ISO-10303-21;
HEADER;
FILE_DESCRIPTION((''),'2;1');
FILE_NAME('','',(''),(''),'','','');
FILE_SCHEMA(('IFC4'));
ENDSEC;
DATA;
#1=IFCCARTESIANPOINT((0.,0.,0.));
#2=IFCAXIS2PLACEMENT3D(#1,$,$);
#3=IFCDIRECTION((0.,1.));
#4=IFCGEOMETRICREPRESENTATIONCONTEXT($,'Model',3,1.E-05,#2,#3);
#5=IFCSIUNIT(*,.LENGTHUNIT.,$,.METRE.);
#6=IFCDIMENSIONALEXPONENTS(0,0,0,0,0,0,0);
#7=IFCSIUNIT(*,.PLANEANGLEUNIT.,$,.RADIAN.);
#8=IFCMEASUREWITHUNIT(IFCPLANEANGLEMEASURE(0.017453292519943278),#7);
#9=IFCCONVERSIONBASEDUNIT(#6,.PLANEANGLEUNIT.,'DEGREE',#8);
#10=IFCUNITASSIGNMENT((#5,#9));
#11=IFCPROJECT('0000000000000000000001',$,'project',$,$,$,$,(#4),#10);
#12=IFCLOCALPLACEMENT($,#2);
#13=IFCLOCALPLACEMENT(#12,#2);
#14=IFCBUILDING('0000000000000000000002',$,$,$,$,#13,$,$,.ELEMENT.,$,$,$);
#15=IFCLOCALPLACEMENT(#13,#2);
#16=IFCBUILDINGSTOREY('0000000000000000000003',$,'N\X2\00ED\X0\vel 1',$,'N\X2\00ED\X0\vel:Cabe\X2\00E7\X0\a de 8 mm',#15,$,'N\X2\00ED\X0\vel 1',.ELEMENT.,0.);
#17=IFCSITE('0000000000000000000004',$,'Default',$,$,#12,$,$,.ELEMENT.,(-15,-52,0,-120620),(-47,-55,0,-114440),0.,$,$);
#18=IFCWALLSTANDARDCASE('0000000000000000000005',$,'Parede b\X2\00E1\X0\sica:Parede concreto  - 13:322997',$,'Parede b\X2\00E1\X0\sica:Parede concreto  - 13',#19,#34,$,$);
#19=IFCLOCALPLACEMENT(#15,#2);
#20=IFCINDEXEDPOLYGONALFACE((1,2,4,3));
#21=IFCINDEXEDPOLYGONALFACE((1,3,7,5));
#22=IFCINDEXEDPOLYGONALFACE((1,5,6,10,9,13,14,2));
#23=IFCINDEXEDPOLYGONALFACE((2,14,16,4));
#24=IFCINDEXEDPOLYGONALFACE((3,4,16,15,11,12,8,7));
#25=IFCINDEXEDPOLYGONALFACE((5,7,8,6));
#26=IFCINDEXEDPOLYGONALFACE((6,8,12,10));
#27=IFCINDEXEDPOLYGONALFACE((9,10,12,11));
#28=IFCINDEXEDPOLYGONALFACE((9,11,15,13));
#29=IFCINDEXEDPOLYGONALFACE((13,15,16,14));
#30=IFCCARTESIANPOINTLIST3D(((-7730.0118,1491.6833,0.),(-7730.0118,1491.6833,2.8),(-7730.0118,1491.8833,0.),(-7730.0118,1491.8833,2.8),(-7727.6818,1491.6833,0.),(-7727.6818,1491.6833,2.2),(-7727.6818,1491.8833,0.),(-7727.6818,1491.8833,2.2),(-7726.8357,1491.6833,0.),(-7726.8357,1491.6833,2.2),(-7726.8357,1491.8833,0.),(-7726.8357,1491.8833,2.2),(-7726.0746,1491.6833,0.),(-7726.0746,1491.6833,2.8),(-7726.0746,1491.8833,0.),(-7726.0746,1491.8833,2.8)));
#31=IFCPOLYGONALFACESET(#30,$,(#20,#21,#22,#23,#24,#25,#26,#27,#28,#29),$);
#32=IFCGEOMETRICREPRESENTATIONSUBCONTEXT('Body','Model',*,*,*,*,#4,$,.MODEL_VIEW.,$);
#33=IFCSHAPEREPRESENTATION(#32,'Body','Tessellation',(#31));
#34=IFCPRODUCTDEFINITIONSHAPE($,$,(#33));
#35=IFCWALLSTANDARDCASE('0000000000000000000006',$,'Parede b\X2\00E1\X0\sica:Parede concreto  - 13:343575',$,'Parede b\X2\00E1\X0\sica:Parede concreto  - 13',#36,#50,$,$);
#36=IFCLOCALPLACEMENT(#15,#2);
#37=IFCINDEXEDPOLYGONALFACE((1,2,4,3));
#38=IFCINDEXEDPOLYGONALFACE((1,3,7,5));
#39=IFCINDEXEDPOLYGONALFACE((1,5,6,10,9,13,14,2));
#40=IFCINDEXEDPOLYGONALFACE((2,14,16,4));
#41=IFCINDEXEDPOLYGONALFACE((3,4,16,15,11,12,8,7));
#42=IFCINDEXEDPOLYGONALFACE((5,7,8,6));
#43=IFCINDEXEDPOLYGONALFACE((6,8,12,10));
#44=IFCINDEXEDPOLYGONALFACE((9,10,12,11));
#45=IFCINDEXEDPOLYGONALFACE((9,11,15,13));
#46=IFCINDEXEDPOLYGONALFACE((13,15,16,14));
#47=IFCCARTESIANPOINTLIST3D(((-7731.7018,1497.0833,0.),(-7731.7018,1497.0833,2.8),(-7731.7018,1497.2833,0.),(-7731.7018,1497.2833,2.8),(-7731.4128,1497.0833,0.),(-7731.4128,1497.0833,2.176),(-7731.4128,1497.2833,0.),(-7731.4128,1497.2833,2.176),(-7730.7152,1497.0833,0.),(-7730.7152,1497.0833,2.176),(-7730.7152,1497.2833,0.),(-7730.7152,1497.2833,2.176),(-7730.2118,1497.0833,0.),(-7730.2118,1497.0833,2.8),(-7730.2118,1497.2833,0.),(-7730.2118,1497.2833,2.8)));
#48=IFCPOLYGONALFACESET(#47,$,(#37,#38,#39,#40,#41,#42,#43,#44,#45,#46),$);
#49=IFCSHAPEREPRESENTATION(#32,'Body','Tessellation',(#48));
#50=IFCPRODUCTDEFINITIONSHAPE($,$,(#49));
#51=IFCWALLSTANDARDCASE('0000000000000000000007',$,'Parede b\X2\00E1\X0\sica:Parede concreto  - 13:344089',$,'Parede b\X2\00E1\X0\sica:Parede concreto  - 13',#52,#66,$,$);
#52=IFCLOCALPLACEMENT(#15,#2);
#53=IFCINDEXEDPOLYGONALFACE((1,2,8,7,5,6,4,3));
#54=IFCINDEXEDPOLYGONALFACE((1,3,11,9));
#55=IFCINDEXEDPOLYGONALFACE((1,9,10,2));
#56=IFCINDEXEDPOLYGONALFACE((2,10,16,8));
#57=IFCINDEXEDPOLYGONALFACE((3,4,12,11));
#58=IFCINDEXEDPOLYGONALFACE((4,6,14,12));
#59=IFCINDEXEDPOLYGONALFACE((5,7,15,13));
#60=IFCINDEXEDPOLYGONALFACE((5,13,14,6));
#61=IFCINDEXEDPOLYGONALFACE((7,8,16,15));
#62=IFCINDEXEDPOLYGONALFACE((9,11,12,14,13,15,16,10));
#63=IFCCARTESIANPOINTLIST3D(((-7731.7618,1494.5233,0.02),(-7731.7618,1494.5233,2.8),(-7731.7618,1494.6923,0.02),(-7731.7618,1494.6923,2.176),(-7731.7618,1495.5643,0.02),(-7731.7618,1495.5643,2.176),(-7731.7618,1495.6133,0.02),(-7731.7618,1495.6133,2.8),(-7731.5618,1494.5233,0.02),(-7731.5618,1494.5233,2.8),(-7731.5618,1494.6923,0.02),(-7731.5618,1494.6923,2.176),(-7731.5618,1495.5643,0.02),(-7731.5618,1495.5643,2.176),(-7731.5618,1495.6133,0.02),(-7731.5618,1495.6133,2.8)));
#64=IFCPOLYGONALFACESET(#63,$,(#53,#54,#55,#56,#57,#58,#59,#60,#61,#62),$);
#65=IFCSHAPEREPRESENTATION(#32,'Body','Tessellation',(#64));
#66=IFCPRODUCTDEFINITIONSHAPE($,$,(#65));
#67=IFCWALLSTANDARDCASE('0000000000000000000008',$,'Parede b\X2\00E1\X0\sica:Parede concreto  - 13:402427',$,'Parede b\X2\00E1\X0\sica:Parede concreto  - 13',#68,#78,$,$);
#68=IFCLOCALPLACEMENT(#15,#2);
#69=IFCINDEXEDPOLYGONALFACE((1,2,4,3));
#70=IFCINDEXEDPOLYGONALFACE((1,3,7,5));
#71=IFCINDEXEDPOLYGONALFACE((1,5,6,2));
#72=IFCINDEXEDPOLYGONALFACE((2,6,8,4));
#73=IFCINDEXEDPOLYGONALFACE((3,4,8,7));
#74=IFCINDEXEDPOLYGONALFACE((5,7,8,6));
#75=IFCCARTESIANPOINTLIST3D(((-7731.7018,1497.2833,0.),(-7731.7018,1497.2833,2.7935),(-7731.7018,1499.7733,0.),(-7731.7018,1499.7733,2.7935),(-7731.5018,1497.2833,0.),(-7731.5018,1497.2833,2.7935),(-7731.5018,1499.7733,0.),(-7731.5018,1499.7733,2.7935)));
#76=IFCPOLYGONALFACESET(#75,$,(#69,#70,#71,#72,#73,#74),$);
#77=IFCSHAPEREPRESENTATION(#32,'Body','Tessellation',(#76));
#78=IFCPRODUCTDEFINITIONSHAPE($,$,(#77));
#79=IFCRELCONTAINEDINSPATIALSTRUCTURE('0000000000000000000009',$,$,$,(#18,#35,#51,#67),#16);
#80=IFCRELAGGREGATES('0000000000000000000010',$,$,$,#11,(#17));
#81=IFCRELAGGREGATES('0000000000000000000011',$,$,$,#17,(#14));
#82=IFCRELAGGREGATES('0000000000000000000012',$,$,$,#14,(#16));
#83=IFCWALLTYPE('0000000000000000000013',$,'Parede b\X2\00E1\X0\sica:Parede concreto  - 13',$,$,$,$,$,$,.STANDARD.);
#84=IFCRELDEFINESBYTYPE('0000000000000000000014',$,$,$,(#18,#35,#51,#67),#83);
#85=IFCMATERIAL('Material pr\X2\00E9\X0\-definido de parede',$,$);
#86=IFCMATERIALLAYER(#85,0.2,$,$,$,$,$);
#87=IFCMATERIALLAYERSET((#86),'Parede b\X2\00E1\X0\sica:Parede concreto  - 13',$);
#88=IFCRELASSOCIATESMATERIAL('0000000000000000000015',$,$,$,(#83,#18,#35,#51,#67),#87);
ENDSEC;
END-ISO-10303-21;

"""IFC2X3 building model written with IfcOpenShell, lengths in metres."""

from ifc_helpers import new_model, entity, si_unit, converted_unit, direction, frame, frame_2d, origin, place, context, subcontext, project, spatial, rectangle, extrude, clip, halfspace, material, layer, layer_set, layer_usage, type_object, element, save


model = new_model("IFC2X3")

# Units and contexts
model_context = context("Model", 3, precision=1e-05, world=origin(), true_north=direction((0.0, 1.0)))
body_context = subcontext(model_context, "Body", "Model", "MODEL_VIEW")
ifc_project = project(units=[si_unit("LENGTHUNIT", "METRE"), converted_unit("PLANEANGLEUNIT", "DEGREE", entity("IfcPlaneAngleMeasure", 0.017453292519943278), si_unit("PLANEANGLEUNIT", "RADIAN"), dimensions=[0, 0, 0, 0, 0, 0, 0])], contexts=[model_context])

# Site, building, storey
site_placement = place(None, origin())
site = spatial("IfcSite", under=ifc_project, at=site_placement, Name="Default", CompositionType="ELEMENT", RefLatitude=(-15, -52, 0, -120620), RefLongitude=(-47, -55, 0, -114440), RefElevation=0.0)
building_placement = place(site_placement, origin())
building = spatial("IfcBuilding", under=site, at=building_placement, CompositionType="ELEMENT")
storey_placement = place(building_placement, origin())
storey = spatial("IfcBuildingStorey", under=building, at=storey_placement, Name="Nível 1", ObjectType="Nível:Cabeça de 8 mm", LongName="Nível 1", CompositionType="ELEMENT", Elevation=0.0)

# Shared definitions
ifc_material_1 = material(Name="Material pré-definido de parede")
ifc_layer = layer(ifc_material_1, 0.2)
ifc_layer_set = layer_set([ifc_layer], Name="Parede básica:Parede concreto  - 13")
wall_type = type_object("IfcWallType", Name="Parede básica:Parede concreto  - 13", PredefinedType="STANDARD", material=ifc_layer_set)

# Walls, openings
ifc_layer_usage_1 = layer_usage(ifc_layer_set, "AXIS2", "POSITIVE", -0.1)
wall_1_placement = place(storey_placement, frame((-7730.0118, 1491.7833, 0.0)))
wall_1 = element("IfcWallStandardCase", 1, at=wall_1_placement, inside=storey, type_object=wall_type, material=ifc_layer_usage_1, Name="Parede básica:Parede concreto  - 13:322997", ObjectType="Parede básica:Parede concreto  - 13", context=body_context, shape_type="SweptSolid", body=[
    extrude(rectangle(XDim=3.9372, YDim=0.2, at=frame_2d((1.9686, 0.0), x_axis=(-1.0, 0.0))), origin(), (0.0, 0.0, 1.0), 2.8),
])
opening_1_placement = place(wall_1_placement, origin())
element("IfcOpeningElement", 2, at=opening_1_placement, cuts=wall_1, ObjectType="Opening", context=body_context, shape_type="SweptSolid", body=[
    extrude(rectangle(XDim=2.2, YDim=0.8461, at=frame_2d((0.0, 0.0), x_axis=(0.0, 1.0))), frame((2.7531, 0.1, 1.1), z_axis=(0.0, -1.0, 0.0), x_axis=(1.0, 0.0, 0.0)), (0.0, 0.0, 1.0), 0.2),
])
ifc_layer_usage_2 = layer_usage(ifc_layer_set, "AXIS2", "NEGATIVE", 0.1)
wall_2_placement = place(storey_placement, frame((-7730.2118, 1497.1833, 0.0), z_axis=(0.0, 0.0, 1.0), x_axis=(-1.0, 0.0, 0.0)))
wall_2 = element("IfcWallStandardCase", 3, at=wall_2_placement, inside=storey, type_object=wall_type, material=ifc_layer_usage_2, Name="Parede básica:Parede concreto  - 13:343575", ObjectType="Parede básica:Parede concreto  - 13", context=body_context, shape_type="SweptSolid", body=[
    extrude(rectangle(XDim=1.49, YDim=0.2, at=frame_2d((0.745, 0.0), x_axis=(-1.0, 0.0))), origin(), (0.0, 0.0, 1.0), 2.8),
])
opening_2_placement = place(wall_2_placement, origin())
element("IfcOpeningElement", 4, at=opening_2_placement, cuts=wall_2, ObjectType="Opening", context=body_context, shape_type="SweptSolid", body=[
    extrude(rectangle(XDim=2.176, YDim=0.6977, at=frame_2d((0.0, 0.0), x_axis=(0.0, 1.0))), frame((0.8522, 0.1, 1.088), z_axis=(0.0, -1.0, 0.0), x_axis=(1.0, 0.0, 0.0)), (0.0, 0.0, 1.0), 0.2),
])
ifc_layer_usage_3 = layer_usage(ifc_layer_set, "AXIS2", "POSITIVE", -0.1)
wall_3_placement = place(storey_placement, frame((-7731.6618, 1494.5233, 0.02), z_axis=(0.0, 0.0, 1.0), x_axis=(0.0, 1.0, 0.0)))
wall_3 = element("IfcWallStandardCase", 5, at=wall_3_placement, inside=storey, type_object=wall_type, material=ifc_layer_usage_3, Name="Parede básica:Parede concreto  - 13:344089", ObjectType="Parede básica:Parede concreto  - 13", context=body_context, shape_type="Clipping", body=[
    clip(extrude(rectangle(XDim=1.09, YDim=0.2, at=frame_2d((0.545, 0.0), x_axis=(-1.0, 0.0))), origin(), (0.0, 0.0, 1.0), 2.78), halfspace(frame((0.169, -0.1, 0.0), z_axis=(0.0, 0.0, -1.0), x_axis=(0.0, 1.0, 0.0)), False)),
])
opening_3_placement = place(wall_3_placement, origin())
element("IfcOpeningElement", 6, at=opening_3_placement, cuts=wall_3, ObjectType="Opening", context=body_context, shape_type="SweptSolid", body=[
    extrude(rectangle(XDim=2.156, YDim=0.872, at=frame_2d((0.0, 0.0), x_axis=(0.0, 1.0))), frame((0.605, 0.1, 1.078), z_axis=(0.0, -1.0, 0.0), x_axis=(1.0, 0.0, 0.0)), (0.0, 0.0, 1.0), 0.2),
])

# Wall
ifc_layer_usage_4 = layer_usage(ifc_layer_set, "AXIS2", "POSITIVE", -0.1)
wall_4_placement = place(storey_placement, frame((-7731.6018, 1499.7733, 0.0), z_axis=(0.0, 0.0, 1.0), x_axis=(0.0, -1.0, 0.0)))
element("IfcWallStandardCase", 7, at=wall_4_placement, inside=storey, type_object=wall_type, material=ifc_layer_usage_4, Name="Parede básica:Parede concreto  - 13:402427", ObjectType="Parede básica:Parede concreto  - 13", context=body_context, shape_type="SweptSolid", body=[
    extrude(rectangle(XDim=2.49, YDim=0.2, at=frame_2d((1.245, 0.0), x_axis=(-1.0, 0.0))), origin(), (0.0, 0.0, 1.0), 2.7935),
])

save(model, "model.ifc")
